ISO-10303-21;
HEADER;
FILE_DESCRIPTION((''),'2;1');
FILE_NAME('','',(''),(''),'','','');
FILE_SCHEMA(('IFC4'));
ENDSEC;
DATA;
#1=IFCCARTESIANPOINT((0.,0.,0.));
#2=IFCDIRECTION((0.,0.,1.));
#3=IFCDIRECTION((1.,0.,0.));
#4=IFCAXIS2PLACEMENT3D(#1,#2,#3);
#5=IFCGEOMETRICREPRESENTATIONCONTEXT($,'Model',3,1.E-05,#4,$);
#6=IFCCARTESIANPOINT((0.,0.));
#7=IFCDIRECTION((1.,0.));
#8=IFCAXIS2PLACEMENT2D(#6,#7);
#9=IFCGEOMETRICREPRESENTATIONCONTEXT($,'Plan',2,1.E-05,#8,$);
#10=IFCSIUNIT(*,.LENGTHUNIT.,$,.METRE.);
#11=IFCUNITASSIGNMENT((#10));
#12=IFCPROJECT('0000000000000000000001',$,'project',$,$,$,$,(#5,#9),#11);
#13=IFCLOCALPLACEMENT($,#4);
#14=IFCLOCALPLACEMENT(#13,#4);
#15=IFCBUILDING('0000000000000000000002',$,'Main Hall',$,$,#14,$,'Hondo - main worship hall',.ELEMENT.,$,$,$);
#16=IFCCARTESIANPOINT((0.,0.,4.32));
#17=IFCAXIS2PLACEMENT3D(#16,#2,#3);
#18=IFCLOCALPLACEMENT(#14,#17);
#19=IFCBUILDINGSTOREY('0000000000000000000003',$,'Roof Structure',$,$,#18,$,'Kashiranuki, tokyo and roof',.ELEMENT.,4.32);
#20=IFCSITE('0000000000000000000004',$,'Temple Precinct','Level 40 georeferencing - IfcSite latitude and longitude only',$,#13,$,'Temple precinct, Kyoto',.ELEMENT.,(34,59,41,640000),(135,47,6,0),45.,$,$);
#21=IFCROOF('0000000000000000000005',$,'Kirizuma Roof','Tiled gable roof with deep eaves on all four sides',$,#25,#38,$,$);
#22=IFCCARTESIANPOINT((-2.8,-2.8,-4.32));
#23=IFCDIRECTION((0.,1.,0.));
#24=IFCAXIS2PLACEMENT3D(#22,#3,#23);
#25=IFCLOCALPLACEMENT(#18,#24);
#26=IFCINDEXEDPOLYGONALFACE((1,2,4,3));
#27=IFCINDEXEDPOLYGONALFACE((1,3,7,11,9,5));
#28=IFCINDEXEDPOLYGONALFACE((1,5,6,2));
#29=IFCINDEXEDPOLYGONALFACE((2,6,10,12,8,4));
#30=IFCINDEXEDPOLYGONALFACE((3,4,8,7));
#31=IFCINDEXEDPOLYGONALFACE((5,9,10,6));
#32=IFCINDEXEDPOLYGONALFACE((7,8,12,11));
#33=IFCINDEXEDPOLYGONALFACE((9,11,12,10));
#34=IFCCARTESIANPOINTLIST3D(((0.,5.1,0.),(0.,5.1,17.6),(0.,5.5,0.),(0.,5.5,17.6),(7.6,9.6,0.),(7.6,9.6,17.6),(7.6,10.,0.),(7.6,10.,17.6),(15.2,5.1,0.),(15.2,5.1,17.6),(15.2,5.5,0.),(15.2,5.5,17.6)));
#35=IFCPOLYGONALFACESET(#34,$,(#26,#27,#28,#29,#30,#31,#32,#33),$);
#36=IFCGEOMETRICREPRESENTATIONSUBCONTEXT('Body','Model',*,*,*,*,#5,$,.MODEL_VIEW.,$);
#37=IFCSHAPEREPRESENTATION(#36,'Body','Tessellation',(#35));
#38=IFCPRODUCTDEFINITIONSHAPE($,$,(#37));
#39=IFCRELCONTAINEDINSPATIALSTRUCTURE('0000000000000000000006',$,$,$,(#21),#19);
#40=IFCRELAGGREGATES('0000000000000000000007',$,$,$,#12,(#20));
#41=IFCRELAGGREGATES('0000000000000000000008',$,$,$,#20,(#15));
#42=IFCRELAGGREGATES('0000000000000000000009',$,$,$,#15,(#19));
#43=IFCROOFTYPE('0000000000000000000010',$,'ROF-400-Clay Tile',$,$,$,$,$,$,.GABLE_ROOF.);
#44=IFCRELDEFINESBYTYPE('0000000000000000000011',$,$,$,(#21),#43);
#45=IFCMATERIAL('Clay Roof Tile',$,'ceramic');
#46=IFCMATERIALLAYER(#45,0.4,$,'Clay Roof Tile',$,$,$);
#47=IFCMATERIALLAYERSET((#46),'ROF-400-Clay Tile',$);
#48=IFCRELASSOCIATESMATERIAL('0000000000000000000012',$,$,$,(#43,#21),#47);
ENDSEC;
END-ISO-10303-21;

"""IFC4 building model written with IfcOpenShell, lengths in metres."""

from ifc_helpers import new_model, si_unit, frame, origin_with_axes, origin_2d_with_axis, place, context, subcontext, project, spatial, line, indexed_curve, outline, extrude, material, layer, layer_set, layer_usage, type_object, element, save


model = new_model("IFC4")

# Units and contexts
model_context = context("Model", 3, precision=1e-05, world=origin_with_axes())
plan_context = context("Plan", 2, precision=1e-05, world=origin_2d_with_axis())
body_context = subcontext(model_context, "Body", "Model", "MODEL_VIEW")
ifc_project = project(units=[si_unit("LENGTHUNIT", "METRE")], contexts=[model_context, plan_context])

# Site, building, storey
site_placement = place(None, origin_with_axes())
site = spatial("IfcSite", under=ifc_project, at=site_placement, Name="Temple Precinct", Description="Level 40 georeferencing - IfcSite latitude and longitude only", LongName="Temple precinct, Kyoto", CompositionType="ELEMENT", RefLatitude=(34, 59, 41, 640000), RefLongitude=(135, 47, 6, 0), RefElevation=45.0)
building_placement = place(site_placement, origin_with_axes())
building = spatial("IfcBuilding", under=site, at=building_placement, Name="Main Hall", LongName="Hondo - main worship hall", CompositionType="ELEMENT")
storey_placement = place(building_placement, frame((0.0, 0.0, 4.32), z_axis=(0.0, 0.0, 1.0), x_axis=(1.0, 0.0, 0.0)))
storey = spatial("IfcBuildingStorey", under=building, at=storey_placement, Name="Roof Structure", LongName="Kashiranuki, tokyo and roof", CompositionType="ELEMENT", Elevation=4.32)

# Roof
ifc_material_1 = material(Name="Clay Roof Tile", Category="ceramic")
ifc_layer = layer(ifc_material_1, 0.4, Name="Clay Roof Tile")
ifc_layer_set = layer_set([ifc_layer], Name="ROF-400-Clay Tile")
ifc_layer_usage = layer_usage(ifc_layer_set, "AXIS3", "POSITIVE", 0.0)
roof_type = type_object("IfcRoofType", Name="ROF-400-Clay Tile", PredefinedType="GABLE_ROOF", material=ifc_layer_set)
roof_placement = place(storey_placement, frame((-2.8, -2.8, -4.32), z_axis=(1.0, 0.0, 0.0), x_axis=(0.0, 1.0, 0.0)))
element("IfcRoof", 1, at=roof_placement, inside=storey, type_object=roof_type, material=ifc_layer_usage, Name="Kirizuma Roof", Description="Tiled gable roof with deep eaves on all four sides", context=body_context, shape_type="SweptSolid", body=[
    extrude(outline(indexed_curve([(0.0, 5.1), (7.6, 9.6), (15.2, 5.1), (15.2, 5.5), (7.6, 10.0), (0.0, 5.5)], segments=[line(1, 2, 3, 4, 5, 6, 1)])), origin_with_axes(), (0.0, 0.0, 1.0), 17.6),
])

save(model, "model.ifc")
